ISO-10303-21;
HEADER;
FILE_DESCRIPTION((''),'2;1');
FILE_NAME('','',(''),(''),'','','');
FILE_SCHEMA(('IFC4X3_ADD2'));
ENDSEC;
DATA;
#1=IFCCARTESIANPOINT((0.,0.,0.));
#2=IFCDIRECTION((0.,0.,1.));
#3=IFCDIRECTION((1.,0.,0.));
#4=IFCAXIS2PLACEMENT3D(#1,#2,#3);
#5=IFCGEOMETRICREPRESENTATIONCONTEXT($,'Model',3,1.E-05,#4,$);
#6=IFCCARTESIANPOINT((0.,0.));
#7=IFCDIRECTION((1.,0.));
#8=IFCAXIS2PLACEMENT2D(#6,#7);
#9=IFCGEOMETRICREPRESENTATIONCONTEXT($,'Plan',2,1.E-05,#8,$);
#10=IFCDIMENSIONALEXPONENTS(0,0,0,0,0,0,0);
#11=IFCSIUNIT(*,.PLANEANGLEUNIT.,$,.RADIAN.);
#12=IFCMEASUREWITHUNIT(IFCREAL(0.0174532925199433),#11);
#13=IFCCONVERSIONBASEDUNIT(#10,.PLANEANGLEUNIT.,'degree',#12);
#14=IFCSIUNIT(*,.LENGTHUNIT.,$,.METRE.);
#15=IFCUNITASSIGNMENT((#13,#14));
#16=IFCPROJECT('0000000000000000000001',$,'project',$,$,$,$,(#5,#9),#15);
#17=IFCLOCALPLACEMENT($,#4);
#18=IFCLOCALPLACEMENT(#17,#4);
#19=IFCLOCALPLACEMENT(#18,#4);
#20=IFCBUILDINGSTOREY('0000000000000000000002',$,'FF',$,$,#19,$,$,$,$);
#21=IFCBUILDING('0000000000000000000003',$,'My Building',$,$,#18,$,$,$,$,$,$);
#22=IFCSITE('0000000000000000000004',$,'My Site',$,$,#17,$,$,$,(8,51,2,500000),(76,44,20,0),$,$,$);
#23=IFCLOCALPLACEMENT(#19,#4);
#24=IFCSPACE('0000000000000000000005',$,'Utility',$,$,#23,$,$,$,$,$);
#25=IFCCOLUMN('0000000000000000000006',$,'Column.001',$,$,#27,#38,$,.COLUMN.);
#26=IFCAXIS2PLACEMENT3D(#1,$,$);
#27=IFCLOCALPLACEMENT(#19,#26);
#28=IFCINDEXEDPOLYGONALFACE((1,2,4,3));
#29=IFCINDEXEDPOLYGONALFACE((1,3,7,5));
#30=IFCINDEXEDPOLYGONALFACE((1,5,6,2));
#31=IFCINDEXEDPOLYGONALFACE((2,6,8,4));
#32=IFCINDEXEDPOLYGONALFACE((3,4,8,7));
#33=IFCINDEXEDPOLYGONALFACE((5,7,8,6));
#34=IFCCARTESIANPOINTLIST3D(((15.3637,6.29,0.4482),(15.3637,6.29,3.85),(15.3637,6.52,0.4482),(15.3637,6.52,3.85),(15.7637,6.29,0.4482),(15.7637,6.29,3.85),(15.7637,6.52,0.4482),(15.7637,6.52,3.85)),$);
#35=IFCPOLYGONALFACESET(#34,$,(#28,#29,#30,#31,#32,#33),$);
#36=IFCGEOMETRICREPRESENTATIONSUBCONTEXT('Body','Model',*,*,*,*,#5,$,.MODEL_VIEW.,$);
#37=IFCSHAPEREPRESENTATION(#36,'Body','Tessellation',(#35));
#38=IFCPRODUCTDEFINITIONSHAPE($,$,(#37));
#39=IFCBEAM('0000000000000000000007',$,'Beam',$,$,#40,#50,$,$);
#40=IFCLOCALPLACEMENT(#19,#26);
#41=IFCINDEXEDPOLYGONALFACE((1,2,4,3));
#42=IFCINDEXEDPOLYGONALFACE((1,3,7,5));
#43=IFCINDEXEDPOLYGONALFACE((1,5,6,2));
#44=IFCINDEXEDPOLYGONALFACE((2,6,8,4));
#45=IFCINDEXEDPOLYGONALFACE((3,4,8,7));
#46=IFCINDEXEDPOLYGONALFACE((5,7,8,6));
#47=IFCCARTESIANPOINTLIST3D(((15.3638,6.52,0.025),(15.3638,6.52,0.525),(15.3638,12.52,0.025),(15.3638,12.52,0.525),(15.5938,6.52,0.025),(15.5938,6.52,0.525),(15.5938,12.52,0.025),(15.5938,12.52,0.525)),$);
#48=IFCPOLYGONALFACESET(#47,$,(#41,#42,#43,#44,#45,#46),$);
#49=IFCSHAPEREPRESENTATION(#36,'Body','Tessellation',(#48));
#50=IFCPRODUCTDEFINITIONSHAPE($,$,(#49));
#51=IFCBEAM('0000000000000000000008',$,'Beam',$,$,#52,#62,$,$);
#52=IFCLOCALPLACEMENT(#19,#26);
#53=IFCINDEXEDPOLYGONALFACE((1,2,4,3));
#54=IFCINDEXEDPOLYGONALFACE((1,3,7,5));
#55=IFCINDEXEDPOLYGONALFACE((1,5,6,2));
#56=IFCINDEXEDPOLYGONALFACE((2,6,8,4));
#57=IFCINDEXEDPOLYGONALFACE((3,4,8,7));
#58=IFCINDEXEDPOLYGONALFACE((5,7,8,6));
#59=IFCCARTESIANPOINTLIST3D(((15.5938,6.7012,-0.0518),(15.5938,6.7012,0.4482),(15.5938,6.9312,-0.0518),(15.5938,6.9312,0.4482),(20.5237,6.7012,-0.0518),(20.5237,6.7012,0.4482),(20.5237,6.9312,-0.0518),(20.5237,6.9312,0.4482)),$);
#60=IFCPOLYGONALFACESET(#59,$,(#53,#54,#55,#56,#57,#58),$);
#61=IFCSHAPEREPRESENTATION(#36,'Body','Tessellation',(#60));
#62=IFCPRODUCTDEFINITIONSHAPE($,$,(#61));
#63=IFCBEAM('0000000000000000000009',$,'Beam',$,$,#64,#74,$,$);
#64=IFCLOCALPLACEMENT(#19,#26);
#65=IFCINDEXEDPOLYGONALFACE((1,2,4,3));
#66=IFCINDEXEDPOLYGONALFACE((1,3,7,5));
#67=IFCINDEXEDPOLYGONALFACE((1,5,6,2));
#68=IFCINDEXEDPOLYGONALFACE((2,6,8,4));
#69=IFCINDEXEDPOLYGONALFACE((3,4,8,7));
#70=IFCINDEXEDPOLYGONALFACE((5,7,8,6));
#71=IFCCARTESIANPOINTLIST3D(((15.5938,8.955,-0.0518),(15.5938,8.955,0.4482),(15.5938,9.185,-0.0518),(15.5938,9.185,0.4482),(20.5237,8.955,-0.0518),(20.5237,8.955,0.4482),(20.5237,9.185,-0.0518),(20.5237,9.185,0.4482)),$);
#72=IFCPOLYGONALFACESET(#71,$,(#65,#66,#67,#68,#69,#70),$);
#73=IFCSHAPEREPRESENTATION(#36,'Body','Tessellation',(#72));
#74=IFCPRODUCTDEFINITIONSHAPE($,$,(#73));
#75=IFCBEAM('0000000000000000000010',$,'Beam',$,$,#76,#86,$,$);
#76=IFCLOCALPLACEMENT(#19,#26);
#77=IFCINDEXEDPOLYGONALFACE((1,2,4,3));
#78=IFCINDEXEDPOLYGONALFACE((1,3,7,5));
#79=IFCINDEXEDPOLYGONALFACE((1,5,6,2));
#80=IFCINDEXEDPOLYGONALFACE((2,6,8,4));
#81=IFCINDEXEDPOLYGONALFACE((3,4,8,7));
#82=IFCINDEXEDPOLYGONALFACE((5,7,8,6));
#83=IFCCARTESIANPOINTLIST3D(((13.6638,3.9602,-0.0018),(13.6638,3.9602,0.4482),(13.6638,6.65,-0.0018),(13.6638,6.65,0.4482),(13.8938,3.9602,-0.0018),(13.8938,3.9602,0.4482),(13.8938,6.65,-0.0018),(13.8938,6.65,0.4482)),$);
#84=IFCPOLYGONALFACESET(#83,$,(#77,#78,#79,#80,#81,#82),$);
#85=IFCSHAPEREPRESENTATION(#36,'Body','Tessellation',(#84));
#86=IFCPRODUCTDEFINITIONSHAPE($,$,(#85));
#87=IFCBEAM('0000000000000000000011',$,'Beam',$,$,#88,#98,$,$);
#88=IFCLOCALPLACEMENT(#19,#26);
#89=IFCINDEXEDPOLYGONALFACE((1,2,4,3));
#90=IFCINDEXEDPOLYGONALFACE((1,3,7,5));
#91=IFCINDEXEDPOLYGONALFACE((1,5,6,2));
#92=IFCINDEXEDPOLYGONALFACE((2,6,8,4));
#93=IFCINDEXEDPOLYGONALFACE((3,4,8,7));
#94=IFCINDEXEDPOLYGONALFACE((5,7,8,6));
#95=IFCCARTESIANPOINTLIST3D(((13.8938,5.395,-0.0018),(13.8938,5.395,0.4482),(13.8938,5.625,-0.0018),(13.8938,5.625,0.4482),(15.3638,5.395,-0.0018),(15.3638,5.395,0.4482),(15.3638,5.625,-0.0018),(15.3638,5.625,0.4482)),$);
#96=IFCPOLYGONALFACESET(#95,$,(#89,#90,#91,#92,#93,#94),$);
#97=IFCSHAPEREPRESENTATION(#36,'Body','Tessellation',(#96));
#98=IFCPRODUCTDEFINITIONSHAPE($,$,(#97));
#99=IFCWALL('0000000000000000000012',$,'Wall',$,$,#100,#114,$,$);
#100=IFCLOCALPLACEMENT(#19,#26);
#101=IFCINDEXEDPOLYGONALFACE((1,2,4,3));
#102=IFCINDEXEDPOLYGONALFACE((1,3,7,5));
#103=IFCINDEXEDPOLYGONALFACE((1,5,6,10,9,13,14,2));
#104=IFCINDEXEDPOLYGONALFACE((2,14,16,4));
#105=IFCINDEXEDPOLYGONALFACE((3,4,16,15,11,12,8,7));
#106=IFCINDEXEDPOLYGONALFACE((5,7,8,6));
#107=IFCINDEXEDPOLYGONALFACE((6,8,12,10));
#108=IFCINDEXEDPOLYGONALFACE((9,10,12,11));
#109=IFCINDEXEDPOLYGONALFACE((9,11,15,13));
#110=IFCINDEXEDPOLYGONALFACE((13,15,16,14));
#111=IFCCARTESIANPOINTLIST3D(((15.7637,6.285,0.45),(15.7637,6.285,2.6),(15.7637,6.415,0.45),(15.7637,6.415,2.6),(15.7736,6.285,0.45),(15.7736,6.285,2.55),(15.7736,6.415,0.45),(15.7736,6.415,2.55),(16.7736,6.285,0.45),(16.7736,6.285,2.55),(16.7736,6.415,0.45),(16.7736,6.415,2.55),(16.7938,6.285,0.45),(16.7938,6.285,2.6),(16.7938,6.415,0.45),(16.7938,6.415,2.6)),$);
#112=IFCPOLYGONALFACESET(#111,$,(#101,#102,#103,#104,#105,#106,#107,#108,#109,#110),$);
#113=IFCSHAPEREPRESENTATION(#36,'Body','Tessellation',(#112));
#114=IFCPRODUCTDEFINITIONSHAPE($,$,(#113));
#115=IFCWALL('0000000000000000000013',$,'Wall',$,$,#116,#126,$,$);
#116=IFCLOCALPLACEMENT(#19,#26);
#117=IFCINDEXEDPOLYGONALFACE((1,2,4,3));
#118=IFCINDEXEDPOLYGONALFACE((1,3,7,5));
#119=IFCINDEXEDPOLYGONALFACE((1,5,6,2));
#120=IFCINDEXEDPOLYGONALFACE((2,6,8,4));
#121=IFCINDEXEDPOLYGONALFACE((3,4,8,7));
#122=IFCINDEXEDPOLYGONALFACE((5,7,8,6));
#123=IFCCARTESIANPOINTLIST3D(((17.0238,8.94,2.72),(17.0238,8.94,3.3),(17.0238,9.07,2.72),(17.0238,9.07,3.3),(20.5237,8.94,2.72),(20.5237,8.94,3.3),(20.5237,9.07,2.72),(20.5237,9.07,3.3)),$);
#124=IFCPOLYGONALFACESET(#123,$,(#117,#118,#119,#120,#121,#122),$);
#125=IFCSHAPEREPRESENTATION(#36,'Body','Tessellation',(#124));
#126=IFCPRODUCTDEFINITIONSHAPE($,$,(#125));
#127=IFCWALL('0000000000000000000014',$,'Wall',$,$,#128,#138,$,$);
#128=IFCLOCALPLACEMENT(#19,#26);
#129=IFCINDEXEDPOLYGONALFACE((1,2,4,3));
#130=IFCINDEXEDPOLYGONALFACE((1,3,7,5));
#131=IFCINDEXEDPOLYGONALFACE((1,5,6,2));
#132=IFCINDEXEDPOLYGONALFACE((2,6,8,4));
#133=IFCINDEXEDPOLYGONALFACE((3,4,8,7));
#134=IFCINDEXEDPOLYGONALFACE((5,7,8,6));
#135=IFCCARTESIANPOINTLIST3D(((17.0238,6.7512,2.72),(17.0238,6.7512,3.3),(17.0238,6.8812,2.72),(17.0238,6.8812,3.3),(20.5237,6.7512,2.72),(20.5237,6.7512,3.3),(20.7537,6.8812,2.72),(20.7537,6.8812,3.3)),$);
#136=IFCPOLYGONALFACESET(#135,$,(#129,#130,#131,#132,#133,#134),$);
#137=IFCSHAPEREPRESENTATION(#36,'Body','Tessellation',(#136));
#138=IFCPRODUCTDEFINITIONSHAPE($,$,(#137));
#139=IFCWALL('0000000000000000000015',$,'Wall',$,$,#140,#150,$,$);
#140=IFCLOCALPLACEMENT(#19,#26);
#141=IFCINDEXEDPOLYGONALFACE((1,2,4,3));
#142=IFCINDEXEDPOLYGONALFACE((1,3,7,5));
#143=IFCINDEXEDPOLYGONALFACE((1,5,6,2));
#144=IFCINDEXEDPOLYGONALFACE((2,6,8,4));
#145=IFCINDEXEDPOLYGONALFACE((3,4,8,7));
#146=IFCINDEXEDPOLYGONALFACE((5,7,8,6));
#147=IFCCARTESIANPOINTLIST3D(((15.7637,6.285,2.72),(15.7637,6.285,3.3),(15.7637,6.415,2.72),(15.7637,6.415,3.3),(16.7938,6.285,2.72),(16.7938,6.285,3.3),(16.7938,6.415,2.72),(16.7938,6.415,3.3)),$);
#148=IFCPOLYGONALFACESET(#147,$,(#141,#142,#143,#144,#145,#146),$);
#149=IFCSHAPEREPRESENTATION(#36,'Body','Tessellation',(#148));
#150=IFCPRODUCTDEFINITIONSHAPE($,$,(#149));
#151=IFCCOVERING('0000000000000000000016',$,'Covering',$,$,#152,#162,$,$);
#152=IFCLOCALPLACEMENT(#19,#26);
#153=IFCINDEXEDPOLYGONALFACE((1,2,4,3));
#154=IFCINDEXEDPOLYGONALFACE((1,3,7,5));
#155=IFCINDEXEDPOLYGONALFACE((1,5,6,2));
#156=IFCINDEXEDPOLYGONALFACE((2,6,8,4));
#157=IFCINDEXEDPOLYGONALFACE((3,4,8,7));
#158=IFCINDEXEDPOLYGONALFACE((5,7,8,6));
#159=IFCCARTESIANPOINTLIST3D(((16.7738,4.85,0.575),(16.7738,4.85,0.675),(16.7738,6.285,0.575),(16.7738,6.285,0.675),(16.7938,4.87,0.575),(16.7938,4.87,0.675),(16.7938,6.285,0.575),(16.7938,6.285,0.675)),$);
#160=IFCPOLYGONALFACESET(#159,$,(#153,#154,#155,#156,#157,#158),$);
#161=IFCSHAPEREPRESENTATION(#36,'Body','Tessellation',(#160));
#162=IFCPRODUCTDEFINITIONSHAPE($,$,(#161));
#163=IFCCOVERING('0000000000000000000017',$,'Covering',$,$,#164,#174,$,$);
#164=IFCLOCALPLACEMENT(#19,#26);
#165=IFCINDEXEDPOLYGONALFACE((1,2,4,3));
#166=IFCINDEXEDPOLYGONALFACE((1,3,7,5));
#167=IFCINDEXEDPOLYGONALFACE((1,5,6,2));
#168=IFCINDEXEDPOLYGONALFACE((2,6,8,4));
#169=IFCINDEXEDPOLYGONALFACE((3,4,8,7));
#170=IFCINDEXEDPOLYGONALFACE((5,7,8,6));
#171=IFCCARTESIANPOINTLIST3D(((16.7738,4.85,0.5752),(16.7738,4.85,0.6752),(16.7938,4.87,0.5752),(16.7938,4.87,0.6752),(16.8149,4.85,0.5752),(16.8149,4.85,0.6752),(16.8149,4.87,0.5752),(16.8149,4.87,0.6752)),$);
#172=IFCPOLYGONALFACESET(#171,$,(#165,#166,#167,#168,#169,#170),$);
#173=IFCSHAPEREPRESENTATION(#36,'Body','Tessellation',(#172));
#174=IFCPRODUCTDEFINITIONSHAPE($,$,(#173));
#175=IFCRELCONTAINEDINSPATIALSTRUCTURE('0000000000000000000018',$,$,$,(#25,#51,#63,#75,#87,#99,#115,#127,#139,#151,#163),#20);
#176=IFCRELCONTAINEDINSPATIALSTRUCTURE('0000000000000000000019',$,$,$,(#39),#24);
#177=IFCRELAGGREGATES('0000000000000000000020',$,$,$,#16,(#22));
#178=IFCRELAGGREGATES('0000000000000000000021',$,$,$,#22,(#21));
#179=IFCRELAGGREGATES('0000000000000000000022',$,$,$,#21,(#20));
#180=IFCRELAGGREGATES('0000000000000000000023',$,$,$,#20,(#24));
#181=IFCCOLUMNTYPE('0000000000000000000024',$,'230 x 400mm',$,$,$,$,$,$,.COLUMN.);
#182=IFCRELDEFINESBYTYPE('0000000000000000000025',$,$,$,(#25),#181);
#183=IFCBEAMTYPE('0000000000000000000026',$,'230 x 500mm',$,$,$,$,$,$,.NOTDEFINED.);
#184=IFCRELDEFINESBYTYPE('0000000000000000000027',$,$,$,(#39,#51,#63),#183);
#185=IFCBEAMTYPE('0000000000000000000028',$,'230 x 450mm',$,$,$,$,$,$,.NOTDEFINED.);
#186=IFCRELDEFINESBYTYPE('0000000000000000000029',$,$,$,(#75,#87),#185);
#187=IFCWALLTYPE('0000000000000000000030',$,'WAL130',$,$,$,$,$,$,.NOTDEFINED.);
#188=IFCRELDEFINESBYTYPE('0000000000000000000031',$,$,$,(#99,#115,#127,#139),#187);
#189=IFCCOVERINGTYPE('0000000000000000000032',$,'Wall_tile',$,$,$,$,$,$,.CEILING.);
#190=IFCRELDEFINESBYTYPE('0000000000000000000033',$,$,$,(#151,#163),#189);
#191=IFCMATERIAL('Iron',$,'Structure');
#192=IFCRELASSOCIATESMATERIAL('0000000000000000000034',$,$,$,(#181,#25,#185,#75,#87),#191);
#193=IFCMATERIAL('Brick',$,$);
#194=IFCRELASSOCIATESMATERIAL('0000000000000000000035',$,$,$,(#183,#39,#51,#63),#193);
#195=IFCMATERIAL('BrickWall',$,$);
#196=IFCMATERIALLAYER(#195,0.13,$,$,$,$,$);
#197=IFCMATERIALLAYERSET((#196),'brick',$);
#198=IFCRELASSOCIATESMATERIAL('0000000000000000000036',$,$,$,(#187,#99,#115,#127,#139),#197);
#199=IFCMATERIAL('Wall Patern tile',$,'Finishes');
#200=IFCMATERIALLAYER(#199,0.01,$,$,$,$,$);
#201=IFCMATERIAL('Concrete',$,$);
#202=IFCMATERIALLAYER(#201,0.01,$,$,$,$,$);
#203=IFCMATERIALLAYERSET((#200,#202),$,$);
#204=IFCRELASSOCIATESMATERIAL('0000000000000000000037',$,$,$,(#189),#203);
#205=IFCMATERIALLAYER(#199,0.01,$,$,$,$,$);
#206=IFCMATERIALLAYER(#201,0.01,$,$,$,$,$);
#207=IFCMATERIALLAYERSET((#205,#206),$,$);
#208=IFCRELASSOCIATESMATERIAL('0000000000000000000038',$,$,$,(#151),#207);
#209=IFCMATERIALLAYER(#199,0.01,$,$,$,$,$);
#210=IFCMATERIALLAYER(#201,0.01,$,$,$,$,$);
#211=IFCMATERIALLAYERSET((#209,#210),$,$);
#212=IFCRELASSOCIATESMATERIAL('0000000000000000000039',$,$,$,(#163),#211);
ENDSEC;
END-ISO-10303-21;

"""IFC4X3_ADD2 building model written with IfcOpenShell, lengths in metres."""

from ifc_helpers import new_model, entity, si_unit, converted_unit, frame, origin_with_axes, origin_2d_with_axis, place, context, subcontext, project, spatial, line, indexed_curve, rectangle, outline, extrude, source, transform, mapped, material, layer, layer_set, layer_usage, material_profile, profile_set, profile_usage, type_object, element, save


model = new_model("IFC4X3_ADD2")

# Units and contexts
model_context = context("Model", 3, precision=1e-05, world=origin_with_axes())
plan_context = context("Plan", 2, precision=1e-05, world=origin_2d_with_axis())
body_context = subcontext(model_context, "Body", "Model", "MODEL_VIEW")
ifc_project = project(units=[converted_unit("PLANEANGLEUNIT", "degree", entity("IfcReal", 0.0174532925199433), si_unit("PLANEANGLEUNIT", "RADIAN"), dimensions=[0, 0, 0, 0, 0, 0, 0]), si_unit("LENGTHUNIT", "METRE")], contexts=[model_context, plan_context])

# Site, building, storey
site_placement = place(None, origin_with_axes())
site = spatial("IfcSite", under=ifc_project, at=site_placement, Name="My Site", RefLatitude=(8, 51, 2, 500000), RefLongitude=(76, 44, 20, 0))
building_placement = place(site_placement, origin_with_axes())
building = spatial("IfcBuilding", under=site, at=building_placement, Name="My Building")
storey_placement = place(building_placement, origin_with_axes())
storey = spatial("IfcBuildingStorey", under=building, at=storey_placement, Name="FF")

# Column
ifc_material_1 = material(Name="Iron", Category="Structure")
ifc_material_profile_1 = material_profile(ifc_material_1, outline(indexed_curve([(-0.115, 0.2), (0.115, 0.2), (0.115, -0.2), (-0.115, -0.2), (-0.115, 0.2)])))
ifc_profile_set_1 = profile_set([ifc_material_profile_1])
ifc_profile_usage_1 = profile_usage(ifc_profile_set_1)
column_type = type_object("IfcColumnType", Name="230 x 400mm", PredefinedType="COLUMN", material=ifc_profile_set_1)
column_placement = place(storey_placement, frame((15.5637, 6.405, 0.4482), z_axis=(0.0, 0.0, 1.0), x_axis=(0.0, 1.0, 0.0)))
element("IfcColumn", 1, at=column_placement, inside=storey, type_object=column_type, material=ifc_profile_usage_1, Name="Column.001", PredefinedType="COLUMN", context=body_context, shape_type="SweptSolid", body=[
    extrude(outline(indexed_curve([(-0.115, 0.2), (0.115, 0.2), (0.115, -0.2), (-0.115, -0.2), (-0.115, 0.2)])), origin_with_axes(), (0.0, 0.0, 1.0), 3.4018),
])

# Shared definitions
space_placement = place(storey_placement, origin_with_axes())
space = spatial("IfcSpace", under=storey, at=space_placement, Name="Utility")

# Beams
ifc_material_2 = material(Name="Brick")
ifc_material_profile_2 = material_profile(ifc_material_2, rectangle(XDim=0.23, YDim=0.5))
ifc_profile_set_2 = profile_set([ifc_material_profile_2], Name="rcc")
ifc_profile_usage_2 = profile_usage(ifc_profile_set_2)
beam_type_1 = type_object("IfcBeamType", Name="230 x 500mm", PredefinedType="NOTDEFINED", material=ifc_profile_set_2)
beam_1_placement = place(space_placement, frame((15.4788, 6.52, 0.275), z_axis=(0.0, 1.0, 0.0), x_axis=(-1.0, 0.0, 0.0)))
element("IfcBeam", 2, at=beam_1_placement, inside=space, type_object=beam_type_1, material=ifc_profile_usage_2, Name="Beam", context=body_context, shape_type="SweptSolid", body=[
    extrude(rectangle(XDim=0.23, YDim=0.5), origin_with_axes(), (0.0, 0.0, 1.0), 6.0),
])
ifc_profile_usage_3 = profile_usage(ifc_profile_set_2)
beam_2_placement = place(storey_placement, frame((15.5938, 6.8162, 0.1982), z_axis=(1.0, 0.0, 0.0), x_axis=(0.0, 1.0, 0.0)))
element("IfcBeam", 3, at=beam_2_placement, inside=storey, type_object=beam_type_1, material=ifc_profile_usage_3, Name="Beam", context=body_context, shape_type="SweptSolid", body=[
    extrude(rectangle(XDim=0.23, YDim=0.5), origin_with_axes(), (0.0, 0.0, 1.0), 4.9299),
])
ifc_profile_usage_4 = profile_usage(ifc_profile_set_2)
beam_3_placement = place(storey_placement, frame((15.5938, 9.07, 0.1982), z_axis=(1.0, 0.0, 0.0), x_axis=(0.0, 1.0, 0.0)))
element("IfcBeam", 4, at=beam_3_placement, inside=storey, type_object=beam_type_1, material=ifc_profile_usage_4, Name="Beam", context=body_context, shape_type="SweptSolid", body=[
    extrude(rectangle(XDim=0.23, YDim=0.5), origin_with_axes(), (0.0, 0.0, 1.0), 4.9299),
])
ifc_material_profile_3 = material_profile(ifc_material_1, rectangle(XDim=0.23, YDim=0.45))
ifc_profile_set_3 = profile_set([ifc_material_profile_3], Name="blank")
ifc_profile_usage_5 = profile_usage(ifc_profile_set_3)
beam_type_2 = type_object("IfcBeamType", Name="230 x 450mm", PredefinedType="NOTDEFINED", material=ifc_profile_set_3)
beam_4_placement = place(storey_placement, frame((13.7788, 6.65, 0.2232), z_axis=(0.0, -1.0, 0.0), x_axis=(1.0, 0.0, 0.0)))
element("IfcBeam", 5, at=beam_4_placement, inside=storey, type_object=beam_type_2, material=ifc_profile_usage_5, Name="Beam", context=body_context, shape_type="SweptSolid", body=[
    extrude(rectangle(XDim=0.23, YDim=0.45), origin_with_axes(), (0.0, 0.0, 1.0), 2.6898),
])
ifc_profile_usage_6 = profile_usage(ifc_profile_set_3)
beam_5_placement = place(storey_placement, frame((13.8938, 5.51, 0.2232), z_axis=(1.0, 0.0, 0.0), x_axis=(0.0, 1.0, 0.0)))
element("IfcBeam", 6, at=beam_5_placement, inside=storey, type_object=beam_type_2, material=ifc_profile_usage_6, Name="Beam", context=body_context, shape_type="SweptSolid", body=[
    extrude(rectangle(XDim=0.23, YDim=0.45), origin_with_axes(), (0.0, 0.0, 1.0), 1.47),
])

# Shared definitions
ifc_material_3 = material(Name="BrickWall")

# Wall, opening
ifc_layer_1 = layer(ifc_material_3, 0.13)
ifc_layer_set_1 = layer_set([ifc_layer_1], Name="brick")
wall_type_1 = type_object("IfcWallType", Name="WAL130", PredefinedType="NOTDEFINED", material=ifc_layer_set_1)
ifc_layer_usage_1 = layer_usage(ifc_layer_set_1, "AXIS2", "POSITIVE", 0.0)
wall_1_placement = place(storey_placement, frame((15.7637, 6.285, 0.45), z_axis=(0.0, 0.0, 1.0), x_axis=(1.0, 0.0, 0.0)))
wall_1 = element("IfcWall", 7, at=wall_1_placement, inside=storey, type_object=wall_type_1, material=ifc_layer_usage_1, Name="Wall", context=body_context, shape_type="SweptSolid", body=[
    extrude(outline(indexed_curve([(0.0, 0.0), (0.0, 0.13), (1.0301, 0.13), (1.0301, 0.0)], segments=[line(1, 2, 3, 4, 1)])), origin_with_axes(), (0.0, 0.0, 1.0), 2.15),
])
shared_shape_1 = source(origin_with_axes(), body_context, "Body", "SweptSolid", [
    extrude(outline(indexed_curve([(0.0, 0.0), (1.0, 0.0), (1.0, 2.1), (0.0, 2.1)], segments=[line(1, 2, 3, 4, 1)])), frame((0.0, -0.6, 0.0), z_axis=(0.0, -1.0, 0.0), x_axis=(1.0, 0.0, 0.0)), (0.0, 0.0, -1.0), 1.2),
])
opening_1_placement = place(wall_1_placement, frame((0.0099, 0.0, 0.0), z_axis=(0.0, 0.0, 1.0), x_axis=(1.0, 0.0, 0.0)))
element("IfcOpeningElement", 8, at=opening_1_placement, cuts=wall_1, PredefinedType="OPENING", context=body_context, shape_type="MappedRepresentation", body=[
    mapped(shared_shape_1, transform((0.0, 0.0, 0.0), x_axis=(1.0, 0.0, 0.0), y_axis=(0.0, 1.0, 0.0), z_axis=(0.0, 0.0, 1.0), scale=1.0)),
])

# Walls
ifc_layer_usage_2 = layer_usage(ifc_layer_set_1, "AXIS2", "POSITIVE", 0.0)
wall_2_placement = place(storey_placement, frame((17.0238, 8.94, 2.72), z_axis=(0.0, 0.0, 1.0), x_axis=(1.0, 0.0, 0.0)))
element("IfcWall", 9, at=wall_2_placement, inside=storey, type_object=wall_type_1, material=ifc_layer_usage_2, Name="Wall", context=body_context, shape_type="SweptSolid", body=[
    extrude(outline(indexed_curve([(0.0, 0.0), (0.0, 0.13), (3.4999, 0.13), (3.4999, 0.0)], segments=[line(1, 2, 3, 4, 1)])), origin_with_axes(), (0.0, 0.0, 1.0), 0.58),
])
ifc_layer_usage_3 = layer_usage(ifc_layer_set_1, "AXIS2", "POSITIVE", 0.0)
wall_3_placement = place(storey_placement, frame((16.7938, 6.7512, 2.72), z_axis=(0.0, 0.0, 1.0), x_axis=(1.0, 0.0, 0.0)))
element("IfcWall", 10, at=wall_3_placement, inside=storey, type_object=wall_type_1, material=ifc_layer_usage_3, Name="Wall", context=body_context, shape_type="SweptSolid", body=[
    extrude(outline(indexed_curve([(0.23, 0.0), (0.23, 0.13), (3.9599, 0.13), (3.7299, 0.0)], segments=[line(1, 2, 3, 4, 1)])), origin_with_axes(), (0.0, 0.0, 1.0), 0.58),
])
ifc_layer_usage_4 = layer_usage(ifc_layer_set_1, "AXIS2", "POSITIVE", 0.0)
wall_4_placement = place(storey_placement, frame((15.7637, 6.285, 2.72), z_axis=(0.0, 0.0, 1.0), x_axis=(1.0, 0.0, 0.0)))
element("IfcWall", 11, at=wall_4_placement, inside=storey, type_object=wall_type_1, material=ifc_layer_usage_4, Name="Wall", context=body_context, shape_type="SweptSolid", body=[
    extrude(outline(indexed_curve([(0.0, 0.0), (0.0, 0.13), (1.0301, 0.13), (1.0301, 0.0)], segments=[line(1, 2, 3, 4, 1)])), origin_with_axes(), (0.0, 0.0, 1.0), 0.58),
])

# Coverings
ifc_material_4 = material(Name="Concrete")
ifc_material_5 = material(Name="Wall Patern tile", Category="Finishes")
ifc_layer_2 = layer(ifc_material_5, 0.01)
ifc_layer_3 = layer(ifc_material_4, 0.01)
ifc_layer_set_2 = layer_set([ifc_layer_2, ifc_layer_3])
ifc_layer_usage_5 = layer_usage(ifc_layer_set_2, "AXIS2", "POSITIVE", 0.0)
ifc_layer_4 = layer(ifc_material_5, 0.01)
ifc_layer_5 = layer(ifc_material_4, 0.01)
ifc_layer_set_3 = layer_set([ifc_layer_4, ifc_layer_5])
covering_type_1 = type_object("IfcCoveringType", Name="Wall_tile", PredefinedType="CEILING", material=ifc_layer_set_3)
covering_1_placement = place(storey_placement, frame((16.7738, 6.285, 0.575), z_axis=(0.0, 0.0, 1.0), x_axis=(0.0, -1.0, 0.0)))
element("IfcCovering", 12, at=covering_1_placement, inside=storey, type_object=covering_type_1, material=ifc_layer_usage_5, Name="Covering", context=body_context, shape_type="SweptSolid", body=[
    extrude(outline(indexed_curve([(0.0, 0.0), (0.0, 0.02), (1.415, 0.02), (1.435, 0.0)], segments=[line(1, 2, 3, 4, 1)])), origin_with_axes(), (0.0, 0.0, 1.0), 0.1),
])
ifc_layer_6 = layer(ifc_material_5, 0.01)
ifc_layer_7 = layer(ifc_material_4, 0.01)
ifc_layer_set_4 = layer_set([ifc_layer_6, ifc_layer_7])
ifc_layer_usage_6 = layer_usage(ifc_layer_set_4, "AXIS2", "POSITIVE", 0.0)
covering_2_placement = place(storey_placement, frame((16.7738, 4.85, 0.5752), z_axis=(0.0, 0.0, 1.0), x_axis=(1.0, 0.0, 0.0)))
element("IfcCovering", 13, at=covering_2_placement, inside=storey, type_object=covering_type_1, material=ifc_layer_usage_6, Name="Covering", context=body_context, shape_type="SweptSolid", body=[
    extrude(outline(indexed_curve([(0.0, 0.0), (0.02, 0.02), (0.041, 0.02), (0.041, 0.0)], segments=[line(1, 2, 3, 4, 1)])), origin_with_axes(), (0.0, 0.0, 1.0), 0.1),
])

save(model, "model.ifc")
